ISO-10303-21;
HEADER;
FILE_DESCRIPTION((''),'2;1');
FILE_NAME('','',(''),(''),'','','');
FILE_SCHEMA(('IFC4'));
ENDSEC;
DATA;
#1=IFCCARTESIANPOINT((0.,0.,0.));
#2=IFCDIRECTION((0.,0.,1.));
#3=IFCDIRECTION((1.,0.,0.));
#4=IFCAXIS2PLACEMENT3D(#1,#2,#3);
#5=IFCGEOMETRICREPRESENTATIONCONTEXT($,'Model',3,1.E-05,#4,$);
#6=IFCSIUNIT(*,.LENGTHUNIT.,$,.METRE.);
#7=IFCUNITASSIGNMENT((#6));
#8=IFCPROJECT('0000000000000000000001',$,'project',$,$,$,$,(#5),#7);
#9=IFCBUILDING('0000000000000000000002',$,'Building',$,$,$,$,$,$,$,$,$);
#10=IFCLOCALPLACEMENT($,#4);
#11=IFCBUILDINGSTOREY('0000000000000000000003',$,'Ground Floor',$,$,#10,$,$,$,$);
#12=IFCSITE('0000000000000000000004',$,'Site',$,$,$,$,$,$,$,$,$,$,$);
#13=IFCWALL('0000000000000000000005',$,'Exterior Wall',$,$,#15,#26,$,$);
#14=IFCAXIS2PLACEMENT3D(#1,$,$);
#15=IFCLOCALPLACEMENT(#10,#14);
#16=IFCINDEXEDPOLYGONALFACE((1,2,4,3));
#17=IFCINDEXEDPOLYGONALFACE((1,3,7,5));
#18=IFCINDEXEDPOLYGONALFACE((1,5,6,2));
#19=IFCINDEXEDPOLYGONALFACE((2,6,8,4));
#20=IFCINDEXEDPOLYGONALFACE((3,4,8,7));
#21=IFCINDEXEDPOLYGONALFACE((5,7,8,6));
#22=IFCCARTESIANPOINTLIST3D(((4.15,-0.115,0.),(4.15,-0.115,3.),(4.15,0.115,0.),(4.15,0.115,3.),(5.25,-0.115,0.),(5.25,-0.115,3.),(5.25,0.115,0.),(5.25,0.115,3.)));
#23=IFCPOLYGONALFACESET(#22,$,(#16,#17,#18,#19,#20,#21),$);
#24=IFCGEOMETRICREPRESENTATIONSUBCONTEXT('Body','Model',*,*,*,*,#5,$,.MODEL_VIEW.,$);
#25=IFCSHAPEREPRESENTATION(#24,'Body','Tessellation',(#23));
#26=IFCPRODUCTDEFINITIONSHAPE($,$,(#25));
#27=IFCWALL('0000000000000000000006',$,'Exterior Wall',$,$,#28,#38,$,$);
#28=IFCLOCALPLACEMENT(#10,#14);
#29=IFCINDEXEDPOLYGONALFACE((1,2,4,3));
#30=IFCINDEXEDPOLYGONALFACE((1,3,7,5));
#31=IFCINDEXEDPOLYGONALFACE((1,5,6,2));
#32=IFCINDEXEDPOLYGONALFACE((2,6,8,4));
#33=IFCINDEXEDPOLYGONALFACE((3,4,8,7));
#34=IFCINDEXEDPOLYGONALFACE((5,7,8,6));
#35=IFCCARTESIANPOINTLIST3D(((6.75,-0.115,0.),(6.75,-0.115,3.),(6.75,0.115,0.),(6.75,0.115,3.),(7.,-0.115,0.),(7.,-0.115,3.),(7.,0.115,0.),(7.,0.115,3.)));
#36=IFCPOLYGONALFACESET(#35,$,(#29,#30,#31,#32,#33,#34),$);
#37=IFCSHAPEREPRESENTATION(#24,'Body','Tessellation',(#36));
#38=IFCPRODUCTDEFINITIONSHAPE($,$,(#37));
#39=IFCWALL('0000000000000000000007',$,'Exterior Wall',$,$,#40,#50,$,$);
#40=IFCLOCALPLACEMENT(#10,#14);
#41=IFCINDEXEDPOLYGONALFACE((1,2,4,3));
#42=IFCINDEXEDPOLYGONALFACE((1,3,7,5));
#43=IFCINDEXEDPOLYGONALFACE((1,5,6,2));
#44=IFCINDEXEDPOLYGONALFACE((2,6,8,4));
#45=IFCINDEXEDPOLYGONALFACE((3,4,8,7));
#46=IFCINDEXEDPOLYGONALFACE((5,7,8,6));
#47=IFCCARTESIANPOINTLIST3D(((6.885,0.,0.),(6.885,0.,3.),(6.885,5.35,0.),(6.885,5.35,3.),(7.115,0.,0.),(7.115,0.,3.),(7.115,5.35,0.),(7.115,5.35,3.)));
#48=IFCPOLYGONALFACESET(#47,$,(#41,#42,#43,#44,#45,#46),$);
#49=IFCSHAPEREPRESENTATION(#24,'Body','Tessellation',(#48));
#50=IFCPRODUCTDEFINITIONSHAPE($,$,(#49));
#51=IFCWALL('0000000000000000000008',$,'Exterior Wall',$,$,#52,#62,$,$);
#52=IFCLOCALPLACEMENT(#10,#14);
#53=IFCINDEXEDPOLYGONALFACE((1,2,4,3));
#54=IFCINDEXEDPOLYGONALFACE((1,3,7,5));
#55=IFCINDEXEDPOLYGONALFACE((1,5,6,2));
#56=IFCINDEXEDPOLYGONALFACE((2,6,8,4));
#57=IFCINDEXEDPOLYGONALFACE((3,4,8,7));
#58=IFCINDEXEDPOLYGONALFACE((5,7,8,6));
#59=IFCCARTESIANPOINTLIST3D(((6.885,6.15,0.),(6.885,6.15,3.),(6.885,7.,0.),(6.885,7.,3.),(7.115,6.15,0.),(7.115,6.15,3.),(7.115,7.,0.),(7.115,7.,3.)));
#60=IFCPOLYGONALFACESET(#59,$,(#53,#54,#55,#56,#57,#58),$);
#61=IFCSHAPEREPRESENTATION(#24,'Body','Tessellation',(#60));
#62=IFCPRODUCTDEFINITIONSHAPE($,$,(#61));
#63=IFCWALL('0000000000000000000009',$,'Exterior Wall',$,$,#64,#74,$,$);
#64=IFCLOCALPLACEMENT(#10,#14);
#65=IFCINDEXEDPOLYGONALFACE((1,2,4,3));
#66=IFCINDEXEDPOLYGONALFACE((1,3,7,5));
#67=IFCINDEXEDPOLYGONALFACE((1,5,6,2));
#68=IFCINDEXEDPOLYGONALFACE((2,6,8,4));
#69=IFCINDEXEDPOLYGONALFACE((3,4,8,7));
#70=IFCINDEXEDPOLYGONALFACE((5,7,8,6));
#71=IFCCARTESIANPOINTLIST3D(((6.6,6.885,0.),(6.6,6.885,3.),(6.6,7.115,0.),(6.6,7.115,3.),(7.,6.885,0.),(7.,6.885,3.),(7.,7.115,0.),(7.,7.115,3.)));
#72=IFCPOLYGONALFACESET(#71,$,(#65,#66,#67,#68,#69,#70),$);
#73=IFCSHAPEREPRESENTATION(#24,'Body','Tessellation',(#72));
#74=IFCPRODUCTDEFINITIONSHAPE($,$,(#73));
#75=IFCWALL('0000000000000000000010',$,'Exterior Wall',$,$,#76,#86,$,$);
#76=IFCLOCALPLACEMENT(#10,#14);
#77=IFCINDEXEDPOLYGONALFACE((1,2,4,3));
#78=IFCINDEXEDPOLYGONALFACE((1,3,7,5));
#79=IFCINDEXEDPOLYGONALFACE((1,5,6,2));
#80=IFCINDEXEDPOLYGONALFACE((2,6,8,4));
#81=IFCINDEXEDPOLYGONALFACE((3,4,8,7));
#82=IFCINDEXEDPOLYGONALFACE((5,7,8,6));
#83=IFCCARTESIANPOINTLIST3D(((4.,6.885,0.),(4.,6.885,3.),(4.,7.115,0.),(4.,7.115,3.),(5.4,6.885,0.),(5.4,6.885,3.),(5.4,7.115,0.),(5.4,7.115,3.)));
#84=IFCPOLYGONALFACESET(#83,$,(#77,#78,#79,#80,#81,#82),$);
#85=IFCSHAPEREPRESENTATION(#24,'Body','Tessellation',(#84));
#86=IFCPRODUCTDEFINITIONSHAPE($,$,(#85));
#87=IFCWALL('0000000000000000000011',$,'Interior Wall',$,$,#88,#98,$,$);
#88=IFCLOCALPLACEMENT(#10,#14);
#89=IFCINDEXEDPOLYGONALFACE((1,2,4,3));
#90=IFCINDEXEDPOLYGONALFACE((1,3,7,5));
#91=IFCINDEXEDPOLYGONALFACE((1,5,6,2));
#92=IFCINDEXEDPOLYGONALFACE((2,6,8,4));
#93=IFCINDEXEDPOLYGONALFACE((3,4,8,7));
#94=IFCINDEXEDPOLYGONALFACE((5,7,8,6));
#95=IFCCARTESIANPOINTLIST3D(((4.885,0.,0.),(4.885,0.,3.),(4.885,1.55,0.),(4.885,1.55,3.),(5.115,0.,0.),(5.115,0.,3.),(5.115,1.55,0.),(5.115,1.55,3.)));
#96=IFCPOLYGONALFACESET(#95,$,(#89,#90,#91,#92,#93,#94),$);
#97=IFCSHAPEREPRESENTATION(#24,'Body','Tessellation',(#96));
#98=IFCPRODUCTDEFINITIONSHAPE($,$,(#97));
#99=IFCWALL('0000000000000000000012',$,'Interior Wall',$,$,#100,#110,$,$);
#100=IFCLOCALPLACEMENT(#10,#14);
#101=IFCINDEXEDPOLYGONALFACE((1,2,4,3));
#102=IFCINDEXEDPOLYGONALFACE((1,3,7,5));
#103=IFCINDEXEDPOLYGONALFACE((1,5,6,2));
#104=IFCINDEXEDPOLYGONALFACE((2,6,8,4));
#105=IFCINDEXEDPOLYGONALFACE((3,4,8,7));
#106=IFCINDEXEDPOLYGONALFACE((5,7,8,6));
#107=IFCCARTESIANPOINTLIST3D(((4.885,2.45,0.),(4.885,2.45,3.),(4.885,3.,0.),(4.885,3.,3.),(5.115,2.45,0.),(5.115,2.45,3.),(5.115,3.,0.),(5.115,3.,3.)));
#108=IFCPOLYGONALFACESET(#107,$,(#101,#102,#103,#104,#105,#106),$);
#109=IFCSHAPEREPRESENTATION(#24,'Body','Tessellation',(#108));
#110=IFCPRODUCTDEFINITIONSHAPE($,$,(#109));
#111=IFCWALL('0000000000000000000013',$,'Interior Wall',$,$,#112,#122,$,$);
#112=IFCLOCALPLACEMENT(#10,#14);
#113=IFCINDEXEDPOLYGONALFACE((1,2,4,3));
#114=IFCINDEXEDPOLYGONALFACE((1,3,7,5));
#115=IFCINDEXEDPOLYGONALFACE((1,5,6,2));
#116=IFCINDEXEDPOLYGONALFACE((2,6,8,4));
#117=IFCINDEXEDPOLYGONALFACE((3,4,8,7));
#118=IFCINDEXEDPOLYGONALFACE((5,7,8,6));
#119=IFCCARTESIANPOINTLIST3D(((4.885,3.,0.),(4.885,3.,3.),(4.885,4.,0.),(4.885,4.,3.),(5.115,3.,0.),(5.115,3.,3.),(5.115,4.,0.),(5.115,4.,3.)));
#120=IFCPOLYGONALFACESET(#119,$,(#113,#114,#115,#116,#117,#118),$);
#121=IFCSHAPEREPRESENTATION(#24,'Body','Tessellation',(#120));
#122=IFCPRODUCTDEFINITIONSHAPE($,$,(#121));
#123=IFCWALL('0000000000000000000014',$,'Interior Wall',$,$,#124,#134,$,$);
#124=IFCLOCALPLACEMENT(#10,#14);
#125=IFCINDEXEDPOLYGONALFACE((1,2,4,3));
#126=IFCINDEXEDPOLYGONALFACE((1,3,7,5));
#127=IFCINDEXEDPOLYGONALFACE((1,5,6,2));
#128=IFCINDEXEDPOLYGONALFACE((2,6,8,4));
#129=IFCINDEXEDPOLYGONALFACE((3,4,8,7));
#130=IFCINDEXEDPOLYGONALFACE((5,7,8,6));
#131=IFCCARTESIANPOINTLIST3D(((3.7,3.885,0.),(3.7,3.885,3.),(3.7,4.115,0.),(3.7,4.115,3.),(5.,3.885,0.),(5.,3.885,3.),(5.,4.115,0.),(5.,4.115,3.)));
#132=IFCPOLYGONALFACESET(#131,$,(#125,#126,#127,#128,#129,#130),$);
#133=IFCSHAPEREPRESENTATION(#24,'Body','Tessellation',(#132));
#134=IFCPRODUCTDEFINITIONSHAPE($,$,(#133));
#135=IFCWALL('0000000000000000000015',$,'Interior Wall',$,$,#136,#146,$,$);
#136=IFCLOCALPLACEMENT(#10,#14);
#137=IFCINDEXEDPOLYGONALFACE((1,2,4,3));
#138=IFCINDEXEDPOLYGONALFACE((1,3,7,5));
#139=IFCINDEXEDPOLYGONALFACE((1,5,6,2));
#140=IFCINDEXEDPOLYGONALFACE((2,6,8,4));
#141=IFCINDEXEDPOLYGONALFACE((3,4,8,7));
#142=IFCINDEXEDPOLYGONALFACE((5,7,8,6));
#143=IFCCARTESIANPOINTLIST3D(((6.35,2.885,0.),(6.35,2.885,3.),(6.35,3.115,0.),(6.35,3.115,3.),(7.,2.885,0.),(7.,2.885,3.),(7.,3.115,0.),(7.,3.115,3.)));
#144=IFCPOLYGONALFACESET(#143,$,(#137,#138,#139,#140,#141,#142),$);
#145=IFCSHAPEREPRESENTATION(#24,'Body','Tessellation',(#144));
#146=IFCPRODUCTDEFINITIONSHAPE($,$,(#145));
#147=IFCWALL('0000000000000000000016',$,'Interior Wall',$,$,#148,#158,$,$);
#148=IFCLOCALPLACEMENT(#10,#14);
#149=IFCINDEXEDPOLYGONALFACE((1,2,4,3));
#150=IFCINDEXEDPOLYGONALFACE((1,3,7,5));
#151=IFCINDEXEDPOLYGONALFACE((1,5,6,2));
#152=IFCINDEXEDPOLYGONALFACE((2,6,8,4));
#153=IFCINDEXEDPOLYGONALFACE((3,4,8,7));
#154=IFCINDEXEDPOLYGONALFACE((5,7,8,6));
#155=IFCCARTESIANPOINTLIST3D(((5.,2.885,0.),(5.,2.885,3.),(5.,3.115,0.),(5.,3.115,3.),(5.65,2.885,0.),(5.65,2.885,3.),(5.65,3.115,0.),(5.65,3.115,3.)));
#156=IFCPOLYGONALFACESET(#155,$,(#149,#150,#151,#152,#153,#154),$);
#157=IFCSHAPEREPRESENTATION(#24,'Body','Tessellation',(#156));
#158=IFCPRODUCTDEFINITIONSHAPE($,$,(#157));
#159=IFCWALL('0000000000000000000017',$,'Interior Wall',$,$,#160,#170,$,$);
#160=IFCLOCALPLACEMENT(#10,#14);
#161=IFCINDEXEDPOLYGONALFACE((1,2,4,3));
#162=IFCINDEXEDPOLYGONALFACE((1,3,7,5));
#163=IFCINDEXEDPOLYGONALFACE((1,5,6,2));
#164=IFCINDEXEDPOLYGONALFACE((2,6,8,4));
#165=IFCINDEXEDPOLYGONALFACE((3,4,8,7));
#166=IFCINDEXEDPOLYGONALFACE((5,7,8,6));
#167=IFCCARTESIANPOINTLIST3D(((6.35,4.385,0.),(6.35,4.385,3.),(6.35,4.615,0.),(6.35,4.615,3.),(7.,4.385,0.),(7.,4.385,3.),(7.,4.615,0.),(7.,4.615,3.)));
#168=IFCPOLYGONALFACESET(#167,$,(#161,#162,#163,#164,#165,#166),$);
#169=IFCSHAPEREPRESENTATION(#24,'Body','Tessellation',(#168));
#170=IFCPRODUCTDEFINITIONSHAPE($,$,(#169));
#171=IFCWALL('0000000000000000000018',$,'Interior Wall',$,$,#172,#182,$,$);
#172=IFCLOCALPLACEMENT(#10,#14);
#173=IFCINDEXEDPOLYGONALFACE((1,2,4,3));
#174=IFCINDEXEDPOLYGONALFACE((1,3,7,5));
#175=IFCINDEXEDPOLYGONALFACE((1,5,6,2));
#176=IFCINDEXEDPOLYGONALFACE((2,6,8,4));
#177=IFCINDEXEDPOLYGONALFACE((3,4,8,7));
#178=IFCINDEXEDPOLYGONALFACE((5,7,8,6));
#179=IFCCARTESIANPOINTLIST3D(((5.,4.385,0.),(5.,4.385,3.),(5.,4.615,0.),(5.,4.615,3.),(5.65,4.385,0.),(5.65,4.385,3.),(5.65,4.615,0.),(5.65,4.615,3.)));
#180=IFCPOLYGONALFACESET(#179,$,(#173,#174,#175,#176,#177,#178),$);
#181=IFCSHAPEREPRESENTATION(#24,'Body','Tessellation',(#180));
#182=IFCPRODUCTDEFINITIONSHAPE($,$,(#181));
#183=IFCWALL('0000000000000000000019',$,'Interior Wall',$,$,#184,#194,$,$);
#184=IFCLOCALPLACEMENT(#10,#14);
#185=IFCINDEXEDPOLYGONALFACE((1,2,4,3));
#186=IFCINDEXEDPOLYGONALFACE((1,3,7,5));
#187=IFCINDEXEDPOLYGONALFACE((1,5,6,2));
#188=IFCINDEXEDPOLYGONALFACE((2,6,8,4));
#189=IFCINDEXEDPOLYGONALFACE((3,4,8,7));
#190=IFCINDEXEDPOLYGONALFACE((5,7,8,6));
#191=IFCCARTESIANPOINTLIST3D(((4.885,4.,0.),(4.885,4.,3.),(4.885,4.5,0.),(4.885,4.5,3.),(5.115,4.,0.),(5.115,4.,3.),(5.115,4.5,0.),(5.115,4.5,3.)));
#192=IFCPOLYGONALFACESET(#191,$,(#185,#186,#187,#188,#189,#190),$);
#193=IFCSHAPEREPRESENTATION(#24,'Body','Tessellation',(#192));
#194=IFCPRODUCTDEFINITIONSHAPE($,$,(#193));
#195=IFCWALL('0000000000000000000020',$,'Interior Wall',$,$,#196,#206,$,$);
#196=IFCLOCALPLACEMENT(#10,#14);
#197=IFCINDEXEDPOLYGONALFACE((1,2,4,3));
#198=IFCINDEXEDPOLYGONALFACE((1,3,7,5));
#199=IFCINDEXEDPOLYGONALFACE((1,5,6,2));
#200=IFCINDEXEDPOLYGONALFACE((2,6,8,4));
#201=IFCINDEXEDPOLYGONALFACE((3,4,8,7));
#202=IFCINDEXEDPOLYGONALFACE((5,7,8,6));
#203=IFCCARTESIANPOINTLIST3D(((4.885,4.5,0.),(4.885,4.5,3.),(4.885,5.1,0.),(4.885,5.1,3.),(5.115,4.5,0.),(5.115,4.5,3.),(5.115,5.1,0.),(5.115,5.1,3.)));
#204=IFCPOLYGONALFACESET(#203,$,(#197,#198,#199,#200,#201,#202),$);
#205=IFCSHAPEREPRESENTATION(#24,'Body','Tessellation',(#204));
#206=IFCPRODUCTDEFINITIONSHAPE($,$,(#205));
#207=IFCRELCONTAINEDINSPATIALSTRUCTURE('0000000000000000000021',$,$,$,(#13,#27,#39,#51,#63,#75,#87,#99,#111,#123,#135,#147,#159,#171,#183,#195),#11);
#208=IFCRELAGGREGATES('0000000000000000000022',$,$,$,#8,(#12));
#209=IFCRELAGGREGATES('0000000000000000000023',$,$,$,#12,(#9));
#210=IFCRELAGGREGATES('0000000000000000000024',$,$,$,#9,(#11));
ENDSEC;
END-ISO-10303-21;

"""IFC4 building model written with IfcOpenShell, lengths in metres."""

from ifc_helpers import new_model, si_unit, frame, origin_with_axes, place, context, subcontext, project, spatial, indexed_curve, outline, extrude, element, save


model = new_model("IFC4")

# Units and contexts
model_context = context("Model", 3, precision=1e-05, world=origin_with_axes())
body_context = subcontext(model_context, "Body", "Model", "MODEL_VIEW")
ifc_project = project(units=[si_unit("LENGTHUNIT", "METRE")], contexts=[model_context])

# Site, building, storey
site = spatial("IfcSite", under=ifc_project, Name="Site")
building = spatial("IfcBuilding", under=site, Name="Building")
storey_placement = place(None, origin_with_axes())
storey = spatial("IfcBuildingStorey", under=building, at=storey_placement, Name="Ground Floor")

# Walls
wall_1_placement = place(storey_placement, frame((4.15, 0.0, 0.0), z_axis=(0.0, 0.0, 1.0), x_axis=(1.0, 0.0, 0.0)))
element("IfcWall", 1, at=wall_1_placement, inside=storey, Name="Exterior Wall", context=body_context, shape_type="SweptSolid", body=[
    extrude(outline(indexed_curve([(0.0, 0.0), (0.0, 0.23), (1.1, 0.23), (1.1, 0.0), (0.0, 0.0)], self_intersect=False)), frame((0.0, -0.115, 0.0), z_axis=(0.0, 0.0, 1.0), x_axis=(1.0, 0.0, 0.0)), (0.0, 0.0, 1.0), 3.0),
])
wall_2_placement = place(storey_placement, frame((6.75, 0.0, 0.0), z_axis=(0.0, 0.0, 1.0), x_axis=(1.0, 0.0, 0.0)))
element("IfcWall", 2, at=wall_2_placement, inside=storey, Name="Exterior Wall", context=body_context, shape_type="SweptSolid", body=[
    extrude(outline(indexed_curve([(0.0, 0.0), (0.0, 0.23), (0.25, 0.23), (0.25, 0.0), (0.0, 0.0)], self_intersect=False)), frame((0.0, -0.115, 0.0), z_axis=(0.0, 0.0, 1.0), x_axis=(1.0, 0.0, 0.0)), (0.0, 0.0, 1.0), 3.0),
])
wall_3_placement = place(storey_placement, frame((7.0, 0.0, 0.0), z_axis=(0.0, 0.0, 1.0), x_axis=(0.0, 1.0, 0.0)))
element("IfcWall", 3, at=wall_3_placement, inside=storey, Name="Exterior Wall", context=body_context, shape_type="SweptSolid", body=[
    extrude(outline(indexed_curve([(0.0, 0.0), (0.0, 0.23), (5.35, 0.23), (5.35, 0.0), (0.0, 0.0)], self_intersect=False)), frame((0.0, -0.115, 0.0), z_axis=(0.0, 0.0, 1.0), x_axis=(1.0, 0.0, 0.0)), (0.0, 0.0, 1.0), 3.0),
])
wall_4_placement = place(storey_placement, frame((7.0, 6.15, 0.0), z_axis=(0.0, 0.0, 1.0), x_axis=(0.0, 1.0, 0.0)))
element("IfcWall", 4, at=wall_4_placement, inside=storey, Name="Exterior Wall", context=body_context, shape_type="SweptSolid", body=[
    extrude(outline(indexed_curve([(0.0, 0.0), (0.0, 0.23), (0.85, 0.23), (0.85, 0.0), (0.0, 0.0)], self_intersect=False)), frame((0.0, -0.115, 0.0), z_axis=(0.0, 0.0, 1.0), x_axis=(1.0, 0.0, 0.0)), (0.0, 0.0, 1.0), 3.0),
])
wall_5_placement = place(storey_placement, frame((7.0, 7.0, 0.0), z_axis=(0.0, 0.0, 1.0), x_axis=(-1.0, 0.0, 0.0)))
element("IfcWall", 5, at=wall_5_placement, inside=storey, Name="Exterior Wall", context=body_context, shape_type="SweptSolid", body=[
    extrude(outline(indexed_curve([(0.0, 0.0), (0.0, 0.23), (0.4, 0.23), (0.4, 0.0), (0.0, 0.0)], self_intersect=False)), frame((0.0, -0.115, 0.0), z_axis=(0.0, 0.0, 1.0), x_axis=(1.0, 0.0, 0.0)), (0.0, 0.0, 1.0), 3.0),
])
wall_6_placement = place(storey_placement, frame((5.4, 7.0, 0.0), z_axis=(0.0, 0.0, 1.0), x_axis=(-1.0, 0.0, 0.0)))
element("IfcWall", 6, at=wall_6_placement, inside=storey, Name="Exterior Wall", context=body_context, shape_type="SweptSolid", body=[
    extrude(outline(indexed_curve([(0.0, 0.0), (0.0, 0.23), (1.4, 0.23), (1.4, 0.0), (0.0, 0.0)], self_intersect=False)), frame((0.0, -0.115, 0.0), z_axis=(0.0, 0.0, 1.0), x_axis=(1.0, 0.0, 0.0)), (0.0, 0.0, 1.0), 3.0),
])
wall_7_placement = place(storey_placement, frame((5.0, 0.0, 0.0), z_axis=(0.0, 0.0, 1.0), x_axis=(0.0, 1.0, 0.0)))
element("IfcWall", 7, at=wall_7_placement, inside=storey, Name="Interior Wall", context=body_context, shape_type="SweptSolid", body=[
    extrude(outline(indexed_curve([(0.0, 0.0), (0.0, 0.23), (1.55, 0.23), (1.55, 0.0), (0.0, 0.0)], self_intersect=False)), frame((0.0, -0.115, 0.0), z_axis=(0.0, 0.0, 1.0), x_axis=(1.0, 0.0, 0.0)), (0.0, 0.0, 1.0), 3.0),
])
wall_8_placement = place(storey_placement, frame((5.0, 2.45, 0.0), z_axis=(0.0, 0.0, 1.0), x_axis=(0.0, 1.0, 0.0)))
element("IfcWall", 8, at=wall_8_placement, inside=storey, Name="Interior Wall", context=body_context, shape_type="SweptSolid", body=[
    extrude(outline(indexed_curve([(0.0, 0.0), (0.0, 0.23), (0.55, 0.23), (0.55, 0.0), (0.0, 0.0)], self_intersect=False)), frame((0.0, -0.115, 0.0), z_axis=(0.0, 0.0, 1.0), x_axis=(1.0, 0.0, 0.0)), (0.0, 0.0, 1.0), 3.0),
])
wall_9_placement = place(storey_placement, frame((5.0, 3.0, 0.0), z_axis=(0.0, 0.0, 1.0), x_axis=(0.0, 1.0, 0.0)))
element("IfcWall", 9, at=wall_9_placement, inside=storey, Name="Interior Wall", context=body_context, shape_type="SweptSolid", body=[
    extrude(outline(indexed_curve([(0.0, 0.0), (0.0, 0.23), (1.0, 0.23), (1.0, 0.0), (0.0, 0.0)], self_intersect=False)), frame((0.0, -0.115, 0.0), z_axis=(0.0, 0.0, 1.0), x_axis=(1.0, 0.0, 0.0)), (0.0, 0.0, 1.0), 3.0),
])
wall_10_placement = place(storey_placement, frame((5.0, 4.0, 0.0), z_axis=(0.0, 0.0, 1.0), x_axis=(-1.0, 0.0, 0.0)))
element("IfcWall", 10, at=wall_10_placement, inside=storey, Name="Interior Wall", context=body_context, shape_type="SweptSolid", body=[
    extrude(outline(indexed_curve([(0.0, 0.0), (0.0, 0.23), (1.3, 0.23), (1.3, 0.0), (0.0, 0.0)], self_intersect=False)), frame((0.0, -0.115, 0.0), z_axis=(0.0, 0.0, 1.0), x_axis=(1.0, 0.0, 0.0)), (0.0, 0.0, 1.0), 3.0),
])
for number, where, z_axis, x_axis, name in (
    (11, (7.0, 3.0, 0.0), (0.0, 0.0, 1.0), (-1.0, 0.0, 0.0), "Interior Wall"),
    (12, (5.65, 3.0, 0.0), (0.0, 0.0, 1.0), (-1.0, 0.0, 0.0), "Interior Wall"),
    (13, (7.0, 4.5, 0.0), (0.0, 0.0, 1.0), (-1.0, 0.0, 0.0), "Interior Wall"),
    (14, (5.65, 4.5, 0.0), (0.0, 0.0, 1.0), (-1.0, 0.0, 0.0), "Interior Wall"),
):
    element("IfcWall", number, at=place(storey_placement, frame(where, z_axis=z_axis, x_axis=x_axis)), inside=storey, Name=name, context=body_context, shape_type="SweptSolid", body=[
        extrude(outline(indexed_curve([(0.0, 0.0), (0.0, 0.23), (0.65, 0.23), (0.65, 0.0), (0.0, 0.0)], self_intersect=False)), frame((0.0, -0.115, 0.0), z_axis=(0.0, 0.0, 1.0), x_axis=(1.0, 0.0, 0.0)), (0.0, 0.0, 1.0), 3.0),
    ])
wall_11_placement = place(storey_placement, frame((5.0, 4.5, 0.0), z_axis=(0.0, 0.0, 1.0), x_axis=(0.0, -1.0, 0.0)))
element("IfcWall", 15, at=wall_11_placement, inside=storey, Name="Interior Wall", context=body_context, shape_type="SweptSolid", body=[
    extrude(outline(indexed_curve([(0.0, 0.0), (0.0, 0.23), (0.5, 0.23), (0.5, 0.0), (0.0, 0.0)], self_intersect=False)), frame((0.0, -0.115, 0.0), z_axis=(0.0, 0.0, 1.0), x_axis=(1.0, 0.0, 0.0)), (0.0, 0.0, 1.0), 3.0),
])
wall_12_placement = place(storey_placement, frame((5.0, 4.5, 0.0), z_axis=(0.0, 0.0, 1.0), x_axis=(0.0, 1.0, 0.0)))
element("IfcWall", 16, at=wall_12_placement, inside=storey, Name="Interior Wall", context=body_context, shape_type="SweptSolid", body=[
    extrude(outline(indexed_curve([(0.0, 0.0), (0.0, 0.23), (0.6, 0.23), (0.6, 0.0), (0.0, 0.0)], self_intersect=False)), frame((0.0, -0.115, 0.0), z_axis=(0.0, 0.0, 1.0), x_axis=(1.0, 0.0, 0.0)), (0.0, 0.0, 1.0), 3.0),
])

save(model, "model.ifc")
